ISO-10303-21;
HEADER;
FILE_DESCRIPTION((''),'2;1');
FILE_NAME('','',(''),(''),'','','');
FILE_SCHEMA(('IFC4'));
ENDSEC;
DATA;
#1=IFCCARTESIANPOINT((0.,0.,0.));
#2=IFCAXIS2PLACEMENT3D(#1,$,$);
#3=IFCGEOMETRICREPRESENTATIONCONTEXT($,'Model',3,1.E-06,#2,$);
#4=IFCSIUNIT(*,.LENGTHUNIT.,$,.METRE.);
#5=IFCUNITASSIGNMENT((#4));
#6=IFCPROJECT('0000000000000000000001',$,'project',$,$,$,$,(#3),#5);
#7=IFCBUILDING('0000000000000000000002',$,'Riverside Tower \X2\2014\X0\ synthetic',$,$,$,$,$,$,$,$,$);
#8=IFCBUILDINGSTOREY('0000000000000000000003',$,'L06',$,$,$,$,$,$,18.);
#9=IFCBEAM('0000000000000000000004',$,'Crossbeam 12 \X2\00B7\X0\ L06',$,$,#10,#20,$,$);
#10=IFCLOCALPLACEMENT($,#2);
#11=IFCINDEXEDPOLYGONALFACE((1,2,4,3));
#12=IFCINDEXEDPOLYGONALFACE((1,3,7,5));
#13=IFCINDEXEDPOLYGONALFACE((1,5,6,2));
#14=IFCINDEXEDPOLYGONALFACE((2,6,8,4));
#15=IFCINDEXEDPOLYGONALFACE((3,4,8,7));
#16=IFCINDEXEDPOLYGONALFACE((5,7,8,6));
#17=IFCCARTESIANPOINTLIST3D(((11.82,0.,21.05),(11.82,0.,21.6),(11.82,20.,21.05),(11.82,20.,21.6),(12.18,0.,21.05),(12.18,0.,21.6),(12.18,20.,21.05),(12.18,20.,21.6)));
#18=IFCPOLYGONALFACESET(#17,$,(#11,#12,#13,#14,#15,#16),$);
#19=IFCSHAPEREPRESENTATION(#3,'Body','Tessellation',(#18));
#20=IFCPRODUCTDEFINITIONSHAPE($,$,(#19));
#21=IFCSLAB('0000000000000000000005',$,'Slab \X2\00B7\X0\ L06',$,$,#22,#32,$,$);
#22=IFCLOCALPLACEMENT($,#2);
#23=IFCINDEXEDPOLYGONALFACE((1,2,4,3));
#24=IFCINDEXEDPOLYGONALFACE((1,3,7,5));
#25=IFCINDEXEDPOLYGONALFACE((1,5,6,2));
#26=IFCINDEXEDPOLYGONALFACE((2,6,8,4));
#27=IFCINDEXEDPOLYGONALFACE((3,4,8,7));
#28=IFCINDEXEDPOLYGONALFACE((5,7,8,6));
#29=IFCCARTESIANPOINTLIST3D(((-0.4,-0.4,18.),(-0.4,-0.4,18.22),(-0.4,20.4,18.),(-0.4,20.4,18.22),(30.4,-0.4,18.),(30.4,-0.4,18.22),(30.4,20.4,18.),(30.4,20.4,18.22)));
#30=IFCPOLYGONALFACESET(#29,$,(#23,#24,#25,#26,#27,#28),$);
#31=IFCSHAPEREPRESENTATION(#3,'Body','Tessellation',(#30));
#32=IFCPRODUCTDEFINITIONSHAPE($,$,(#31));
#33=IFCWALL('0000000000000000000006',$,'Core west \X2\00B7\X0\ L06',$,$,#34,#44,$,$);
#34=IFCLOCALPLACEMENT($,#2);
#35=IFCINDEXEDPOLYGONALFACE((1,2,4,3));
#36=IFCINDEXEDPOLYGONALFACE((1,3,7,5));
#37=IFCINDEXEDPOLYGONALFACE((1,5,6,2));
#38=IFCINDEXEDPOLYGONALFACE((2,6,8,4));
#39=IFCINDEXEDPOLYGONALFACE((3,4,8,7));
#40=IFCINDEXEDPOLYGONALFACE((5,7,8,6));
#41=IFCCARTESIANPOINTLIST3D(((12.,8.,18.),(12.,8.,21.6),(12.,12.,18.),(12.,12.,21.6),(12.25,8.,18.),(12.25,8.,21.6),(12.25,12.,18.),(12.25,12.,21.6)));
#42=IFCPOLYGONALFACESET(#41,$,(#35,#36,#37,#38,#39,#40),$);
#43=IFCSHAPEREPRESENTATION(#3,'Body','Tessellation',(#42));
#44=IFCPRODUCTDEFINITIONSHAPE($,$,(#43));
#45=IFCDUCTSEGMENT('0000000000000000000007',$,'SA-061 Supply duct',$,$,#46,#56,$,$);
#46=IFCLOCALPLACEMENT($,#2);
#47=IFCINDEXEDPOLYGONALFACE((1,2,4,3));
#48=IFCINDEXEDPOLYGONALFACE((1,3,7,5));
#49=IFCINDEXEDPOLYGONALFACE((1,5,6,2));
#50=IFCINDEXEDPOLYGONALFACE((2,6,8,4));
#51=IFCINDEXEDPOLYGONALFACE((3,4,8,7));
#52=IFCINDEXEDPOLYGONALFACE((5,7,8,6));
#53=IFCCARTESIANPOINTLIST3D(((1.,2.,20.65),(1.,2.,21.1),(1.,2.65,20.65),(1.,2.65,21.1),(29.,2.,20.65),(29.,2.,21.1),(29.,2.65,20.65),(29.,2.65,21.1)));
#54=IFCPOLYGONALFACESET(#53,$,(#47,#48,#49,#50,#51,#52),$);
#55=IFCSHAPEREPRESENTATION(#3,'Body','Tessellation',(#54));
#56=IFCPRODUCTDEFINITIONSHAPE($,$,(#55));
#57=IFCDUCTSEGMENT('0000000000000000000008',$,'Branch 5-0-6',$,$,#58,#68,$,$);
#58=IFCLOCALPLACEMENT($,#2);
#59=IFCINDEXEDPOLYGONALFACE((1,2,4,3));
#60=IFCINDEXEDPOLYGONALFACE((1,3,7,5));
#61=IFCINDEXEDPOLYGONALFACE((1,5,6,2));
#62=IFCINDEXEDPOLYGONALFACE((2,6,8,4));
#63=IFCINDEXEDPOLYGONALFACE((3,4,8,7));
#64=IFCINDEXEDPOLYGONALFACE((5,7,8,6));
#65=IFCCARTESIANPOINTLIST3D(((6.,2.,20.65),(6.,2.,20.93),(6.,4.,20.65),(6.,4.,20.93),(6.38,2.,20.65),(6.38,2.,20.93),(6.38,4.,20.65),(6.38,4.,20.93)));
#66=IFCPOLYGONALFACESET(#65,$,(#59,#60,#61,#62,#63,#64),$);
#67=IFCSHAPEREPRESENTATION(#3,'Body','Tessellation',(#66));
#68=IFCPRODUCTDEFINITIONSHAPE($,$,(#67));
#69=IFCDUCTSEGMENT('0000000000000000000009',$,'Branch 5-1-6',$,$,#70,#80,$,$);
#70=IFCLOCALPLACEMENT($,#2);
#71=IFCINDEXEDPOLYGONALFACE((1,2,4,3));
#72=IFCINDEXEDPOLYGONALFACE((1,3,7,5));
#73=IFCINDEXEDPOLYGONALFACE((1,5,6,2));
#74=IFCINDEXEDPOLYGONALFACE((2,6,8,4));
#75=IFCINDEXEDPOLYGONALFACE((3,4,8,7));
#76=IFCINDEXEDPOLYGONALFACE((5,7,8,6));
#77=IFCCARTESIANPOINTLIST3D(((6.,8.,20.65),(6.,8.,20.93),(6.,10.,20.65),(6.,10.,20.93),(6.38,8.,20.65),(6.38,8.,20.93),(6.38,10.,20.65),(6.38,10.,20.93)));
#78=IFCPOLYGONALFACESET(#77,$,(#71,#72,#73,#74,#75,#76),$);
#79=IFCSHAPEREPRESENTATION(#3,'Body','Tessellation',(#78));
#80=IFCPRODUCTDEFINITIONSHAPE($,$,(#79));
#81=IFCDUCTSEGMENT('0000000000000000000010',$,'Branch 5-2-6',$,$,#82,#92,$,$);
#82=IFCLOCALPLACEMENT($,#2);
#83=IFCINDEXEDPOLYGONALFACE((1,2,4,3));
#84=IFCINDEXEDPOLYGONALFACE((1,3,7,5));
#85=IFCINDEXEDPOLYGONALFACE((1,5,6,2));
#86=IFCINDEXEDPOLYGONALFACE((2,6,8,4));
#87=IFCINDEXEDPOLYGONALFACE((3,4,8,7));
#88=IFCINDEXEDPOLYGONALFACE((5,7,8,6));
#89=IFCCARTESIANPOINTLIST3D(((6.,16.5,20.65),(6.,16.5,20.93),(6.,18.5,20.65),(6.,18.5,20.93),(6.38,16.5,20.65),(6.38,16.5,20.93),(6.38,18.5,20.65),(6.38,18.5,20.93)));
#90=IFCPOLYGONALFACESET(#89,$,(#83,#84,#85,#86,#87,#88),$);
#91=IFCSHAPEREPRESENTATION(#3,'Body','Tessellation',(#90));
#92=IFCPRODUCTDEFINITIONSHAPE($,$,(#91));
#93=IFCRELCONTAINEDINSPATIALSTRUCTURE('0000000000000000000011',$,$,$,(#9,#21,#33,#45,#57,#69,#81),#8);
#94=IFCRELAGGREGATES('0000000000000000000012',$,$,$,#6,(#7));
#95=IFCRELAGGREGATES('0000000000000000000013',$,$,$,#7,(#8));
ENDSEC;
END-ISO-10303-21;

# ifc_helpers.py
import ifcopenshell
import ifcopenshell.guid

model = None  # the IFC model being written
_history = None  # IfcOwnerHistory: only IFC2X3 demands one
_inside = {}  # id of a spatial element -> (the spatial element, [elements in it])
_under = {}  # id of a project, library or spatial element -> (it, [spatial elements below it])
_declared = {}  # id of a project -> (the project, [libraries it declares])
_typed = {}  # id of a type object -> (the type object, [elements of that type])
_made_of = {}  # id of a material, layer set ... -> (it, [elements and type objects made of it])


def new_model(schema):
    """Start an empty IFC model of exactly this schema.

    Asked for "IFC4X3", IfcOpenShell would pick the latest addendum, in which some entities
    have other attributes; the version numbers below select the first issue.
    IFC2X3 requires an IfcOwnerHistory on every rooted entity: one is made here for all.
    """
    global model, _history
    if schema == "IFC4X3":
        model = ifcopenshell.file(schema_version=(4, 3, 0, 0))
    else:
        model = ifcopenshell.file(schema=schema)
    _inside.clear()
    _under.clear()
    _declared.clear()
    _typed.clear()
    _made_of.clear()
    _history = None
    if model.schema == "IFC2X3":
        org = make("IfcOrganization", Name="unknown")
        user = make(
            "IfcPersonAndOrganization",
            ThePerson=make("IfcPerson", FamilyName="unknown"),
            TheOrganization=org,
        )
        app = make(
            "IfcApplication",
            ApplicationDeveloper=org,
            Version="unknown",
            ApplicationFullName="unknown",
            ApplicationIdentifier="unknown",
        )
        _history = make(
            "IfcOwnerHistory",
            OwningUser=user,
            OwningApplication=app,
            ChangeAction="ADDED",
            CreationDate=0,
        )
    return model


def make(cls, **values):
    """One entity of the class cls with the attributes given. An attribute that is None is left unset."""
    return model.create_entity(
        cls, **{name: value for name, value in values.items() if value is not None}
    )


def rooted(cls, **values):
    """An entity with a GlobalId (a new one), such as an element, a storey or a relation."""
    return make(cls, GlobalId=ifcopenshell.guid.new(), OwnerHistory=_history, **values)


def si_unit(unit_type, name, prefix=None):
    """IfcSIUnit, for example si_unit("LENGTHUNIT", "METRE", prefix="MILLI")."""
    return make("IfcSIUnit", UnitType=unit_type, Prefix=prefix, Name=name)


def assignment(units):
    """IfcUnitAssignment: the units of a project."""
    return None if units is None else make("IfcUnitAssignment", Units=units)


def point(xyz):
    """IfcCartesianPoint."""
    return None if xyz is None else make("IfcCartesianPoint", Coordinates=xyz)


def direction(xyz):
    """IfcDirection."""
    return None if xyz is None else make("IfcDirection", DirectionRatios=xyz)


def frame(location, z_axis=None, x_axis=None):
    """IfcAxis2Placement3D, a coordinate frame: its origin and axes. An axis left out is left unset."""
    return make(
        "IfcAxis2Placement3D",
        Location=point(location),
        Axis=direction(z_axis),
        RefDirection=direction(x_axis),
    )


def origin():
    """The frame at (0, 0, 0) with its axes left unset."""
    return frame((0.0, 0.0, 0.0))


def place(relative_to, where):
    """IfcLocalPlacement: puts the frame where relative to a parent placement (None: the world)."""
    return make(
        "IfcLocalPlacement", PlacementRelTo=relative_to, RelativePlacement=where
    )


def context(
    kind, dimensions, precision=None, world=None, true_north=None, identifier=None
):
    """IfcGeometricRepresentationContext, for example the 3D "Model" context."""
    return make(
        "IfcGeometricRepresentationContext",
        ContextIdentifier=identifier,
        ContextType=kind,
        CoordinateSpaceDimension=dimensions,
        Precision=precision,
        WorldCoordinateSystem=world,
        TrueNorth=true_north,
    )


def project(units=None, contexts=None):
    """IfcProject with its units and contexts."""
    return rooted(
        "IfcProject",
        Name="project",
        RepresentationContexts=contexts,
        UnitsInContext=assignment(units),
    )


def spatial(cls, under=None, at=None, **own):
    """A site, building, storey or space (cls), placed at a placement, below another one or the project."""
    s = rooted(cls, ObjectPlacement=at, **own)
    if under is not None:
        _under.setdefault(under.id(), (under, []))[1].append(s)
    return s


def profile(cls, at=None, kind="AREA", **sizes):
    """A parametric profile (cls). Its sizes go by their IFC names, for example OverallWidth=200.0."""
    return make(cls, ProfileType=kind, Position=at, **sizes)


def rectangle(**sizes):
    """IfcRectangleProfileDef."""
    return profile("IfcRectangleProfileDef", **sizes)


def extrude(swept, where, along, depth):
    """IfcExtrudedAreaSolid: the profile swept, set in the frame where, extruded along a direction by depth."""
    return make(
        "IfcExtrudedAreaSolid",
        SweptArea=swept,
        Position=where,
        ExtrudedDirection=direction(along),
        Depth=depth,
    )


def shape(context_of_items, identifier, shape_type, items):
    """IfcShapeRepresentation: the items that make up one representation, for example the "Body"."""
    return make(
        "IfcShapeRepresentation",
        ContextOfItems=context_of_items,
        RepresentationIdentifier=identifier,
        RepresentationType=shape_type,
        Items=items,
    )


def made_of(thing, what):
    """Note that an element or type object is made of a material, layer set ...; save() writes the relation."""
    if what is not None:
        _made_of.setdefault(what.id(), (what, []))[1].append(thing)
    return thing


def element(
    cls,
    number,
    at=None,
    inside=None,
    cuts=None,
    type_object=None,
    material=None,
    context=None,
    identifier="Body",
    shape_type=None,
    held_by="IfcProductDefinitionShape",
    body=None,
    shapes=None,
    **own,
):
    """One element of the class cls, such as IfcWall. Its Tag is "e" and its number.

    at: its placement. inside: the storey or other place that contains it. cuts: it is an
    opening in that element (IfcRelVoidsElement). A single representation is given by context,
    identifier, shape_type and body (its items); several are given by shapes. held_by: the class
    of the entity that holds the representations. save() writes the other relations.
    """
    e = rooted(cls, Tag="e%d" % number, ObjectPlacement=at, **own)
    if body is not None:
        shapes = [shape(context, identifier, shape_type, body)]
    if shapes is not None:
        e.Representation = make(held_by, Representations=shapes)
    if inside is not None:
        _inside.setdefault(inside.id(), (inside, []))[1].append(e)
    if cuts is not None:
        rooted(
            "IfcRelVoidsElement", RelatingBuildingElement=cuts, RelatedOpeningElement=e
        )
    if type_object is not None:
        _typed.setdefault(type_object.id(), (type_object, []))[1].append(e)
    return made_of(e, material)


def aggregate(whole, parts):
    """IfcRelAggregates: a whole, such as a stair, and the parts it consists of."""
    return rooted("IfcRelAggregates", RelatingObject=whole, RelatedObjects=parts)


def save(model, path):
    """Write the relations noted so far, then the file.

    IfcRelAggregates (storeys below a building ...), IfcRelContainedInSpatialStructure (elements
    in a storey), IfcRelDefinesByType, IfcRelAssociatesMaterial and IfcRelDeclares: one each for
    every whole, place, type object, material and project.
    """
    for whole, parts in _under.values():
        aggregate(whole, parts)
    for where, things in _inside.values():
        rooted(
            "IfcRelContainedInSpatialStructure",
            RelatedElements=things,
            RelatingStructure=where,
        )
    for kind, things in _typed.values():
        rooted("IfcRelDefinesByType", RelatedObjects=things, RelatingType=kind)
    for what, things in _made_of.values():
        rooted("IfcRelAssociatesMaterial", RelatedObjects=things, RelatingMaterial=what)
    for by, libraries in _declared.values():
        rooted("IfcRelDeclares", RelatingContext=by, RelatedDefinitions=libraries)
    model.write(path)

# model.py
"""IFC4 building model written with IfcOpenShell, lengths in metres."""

from ifc_helpers import new_model, si_unit, frame, origin, place, context, project, spatial, rectangle, extrude, element, save


model = new_model("IFC4")

# Units and contexts
model_context = context("Model", 3, precision=1e-06, world=origin())
ifc_project = project(units=[si_unit("LENGTHUNIT", "METRE")], contexts=[model_context])

# Building, storey
building = spatial("IfcBuilding", under=ifc_project, Name="Riverside Tower — synthetic")
storey = spatial("IfcBuildingStorey", under=building, Name="L06", Elevation=18.0)

# Beam
for number, where, name in (
    (1, (12.0, 10.0, 21.05), "Crossbeam 12 · L06"),
):
    element("IfcBeam", number, at=place(None, frame(where)), inside=storey, Name=name, context=model_context, shape_type="SweptSolid", body=[
        extrude(rectangle(XDim=0.36, YDim=20.0), origin(), (0.0, 0.0, 1.0), 0.55),
    ])

# Slab
slab_placement = place(None, frame((15.0, 10.0, 18.0)))
element("IfcSlab", 2, at=slab_placement, inside=storey, Name="Slab · L06", context=model_context, shape_type="SweptSolid", body=[
    extrude(rectangle(XDim=30.8, YDim=20.8), origin(), (0.0, 0.0, 1.0), 0.22),
])

# Wall
wall_placement = place(None, frame((12.125, 10.0, 18.0)))
element("IfcWall", 3, at=wall_placement, inside=storey, Name="Core west · L06", context=model_context, shape_type="SweptSolid", body=[
    extrude(rectangle(XDim=0.25, YDim=4.0), origin(), (0.0, 0.0, 1.0), 3.6),
])

# Duct segments
duct_segment_placement = place(None, frame((15.0, 2.325, 20.65)))
element("IfcDuctSegment", 4, at=duct_segment_placement, inside=storey, Name="SA-061 Supply duct", context=model_context, shape_type="SweptSolid", body=[
    extrude(rectangle(XDim=28.0, YDim=0.65), origin(), (0.0, 0.0, 1.0), 0.45),
])
for number, where, name in (
    (5, (6.19, 3.0, 20.65), "Branch 5-0-6"),
    (6, (6.19, 9.0, 20.65), "Branch 5-1-6"),
    (7, (6.19, 17.5, 20.65), "Branch 5-2-6"),
):
    element("IfcDuctSegment", number, at=place(None, frame(where)), inside=storey, Name=name, context=model_context, shape_type="SweptSolid", body=[
        extrude(rectangle(XDim=0.38, YDim=2.0), origin(), (0.0, 0.0, 1.0), 0.28),
    ])

save(model, "model.ifc")
